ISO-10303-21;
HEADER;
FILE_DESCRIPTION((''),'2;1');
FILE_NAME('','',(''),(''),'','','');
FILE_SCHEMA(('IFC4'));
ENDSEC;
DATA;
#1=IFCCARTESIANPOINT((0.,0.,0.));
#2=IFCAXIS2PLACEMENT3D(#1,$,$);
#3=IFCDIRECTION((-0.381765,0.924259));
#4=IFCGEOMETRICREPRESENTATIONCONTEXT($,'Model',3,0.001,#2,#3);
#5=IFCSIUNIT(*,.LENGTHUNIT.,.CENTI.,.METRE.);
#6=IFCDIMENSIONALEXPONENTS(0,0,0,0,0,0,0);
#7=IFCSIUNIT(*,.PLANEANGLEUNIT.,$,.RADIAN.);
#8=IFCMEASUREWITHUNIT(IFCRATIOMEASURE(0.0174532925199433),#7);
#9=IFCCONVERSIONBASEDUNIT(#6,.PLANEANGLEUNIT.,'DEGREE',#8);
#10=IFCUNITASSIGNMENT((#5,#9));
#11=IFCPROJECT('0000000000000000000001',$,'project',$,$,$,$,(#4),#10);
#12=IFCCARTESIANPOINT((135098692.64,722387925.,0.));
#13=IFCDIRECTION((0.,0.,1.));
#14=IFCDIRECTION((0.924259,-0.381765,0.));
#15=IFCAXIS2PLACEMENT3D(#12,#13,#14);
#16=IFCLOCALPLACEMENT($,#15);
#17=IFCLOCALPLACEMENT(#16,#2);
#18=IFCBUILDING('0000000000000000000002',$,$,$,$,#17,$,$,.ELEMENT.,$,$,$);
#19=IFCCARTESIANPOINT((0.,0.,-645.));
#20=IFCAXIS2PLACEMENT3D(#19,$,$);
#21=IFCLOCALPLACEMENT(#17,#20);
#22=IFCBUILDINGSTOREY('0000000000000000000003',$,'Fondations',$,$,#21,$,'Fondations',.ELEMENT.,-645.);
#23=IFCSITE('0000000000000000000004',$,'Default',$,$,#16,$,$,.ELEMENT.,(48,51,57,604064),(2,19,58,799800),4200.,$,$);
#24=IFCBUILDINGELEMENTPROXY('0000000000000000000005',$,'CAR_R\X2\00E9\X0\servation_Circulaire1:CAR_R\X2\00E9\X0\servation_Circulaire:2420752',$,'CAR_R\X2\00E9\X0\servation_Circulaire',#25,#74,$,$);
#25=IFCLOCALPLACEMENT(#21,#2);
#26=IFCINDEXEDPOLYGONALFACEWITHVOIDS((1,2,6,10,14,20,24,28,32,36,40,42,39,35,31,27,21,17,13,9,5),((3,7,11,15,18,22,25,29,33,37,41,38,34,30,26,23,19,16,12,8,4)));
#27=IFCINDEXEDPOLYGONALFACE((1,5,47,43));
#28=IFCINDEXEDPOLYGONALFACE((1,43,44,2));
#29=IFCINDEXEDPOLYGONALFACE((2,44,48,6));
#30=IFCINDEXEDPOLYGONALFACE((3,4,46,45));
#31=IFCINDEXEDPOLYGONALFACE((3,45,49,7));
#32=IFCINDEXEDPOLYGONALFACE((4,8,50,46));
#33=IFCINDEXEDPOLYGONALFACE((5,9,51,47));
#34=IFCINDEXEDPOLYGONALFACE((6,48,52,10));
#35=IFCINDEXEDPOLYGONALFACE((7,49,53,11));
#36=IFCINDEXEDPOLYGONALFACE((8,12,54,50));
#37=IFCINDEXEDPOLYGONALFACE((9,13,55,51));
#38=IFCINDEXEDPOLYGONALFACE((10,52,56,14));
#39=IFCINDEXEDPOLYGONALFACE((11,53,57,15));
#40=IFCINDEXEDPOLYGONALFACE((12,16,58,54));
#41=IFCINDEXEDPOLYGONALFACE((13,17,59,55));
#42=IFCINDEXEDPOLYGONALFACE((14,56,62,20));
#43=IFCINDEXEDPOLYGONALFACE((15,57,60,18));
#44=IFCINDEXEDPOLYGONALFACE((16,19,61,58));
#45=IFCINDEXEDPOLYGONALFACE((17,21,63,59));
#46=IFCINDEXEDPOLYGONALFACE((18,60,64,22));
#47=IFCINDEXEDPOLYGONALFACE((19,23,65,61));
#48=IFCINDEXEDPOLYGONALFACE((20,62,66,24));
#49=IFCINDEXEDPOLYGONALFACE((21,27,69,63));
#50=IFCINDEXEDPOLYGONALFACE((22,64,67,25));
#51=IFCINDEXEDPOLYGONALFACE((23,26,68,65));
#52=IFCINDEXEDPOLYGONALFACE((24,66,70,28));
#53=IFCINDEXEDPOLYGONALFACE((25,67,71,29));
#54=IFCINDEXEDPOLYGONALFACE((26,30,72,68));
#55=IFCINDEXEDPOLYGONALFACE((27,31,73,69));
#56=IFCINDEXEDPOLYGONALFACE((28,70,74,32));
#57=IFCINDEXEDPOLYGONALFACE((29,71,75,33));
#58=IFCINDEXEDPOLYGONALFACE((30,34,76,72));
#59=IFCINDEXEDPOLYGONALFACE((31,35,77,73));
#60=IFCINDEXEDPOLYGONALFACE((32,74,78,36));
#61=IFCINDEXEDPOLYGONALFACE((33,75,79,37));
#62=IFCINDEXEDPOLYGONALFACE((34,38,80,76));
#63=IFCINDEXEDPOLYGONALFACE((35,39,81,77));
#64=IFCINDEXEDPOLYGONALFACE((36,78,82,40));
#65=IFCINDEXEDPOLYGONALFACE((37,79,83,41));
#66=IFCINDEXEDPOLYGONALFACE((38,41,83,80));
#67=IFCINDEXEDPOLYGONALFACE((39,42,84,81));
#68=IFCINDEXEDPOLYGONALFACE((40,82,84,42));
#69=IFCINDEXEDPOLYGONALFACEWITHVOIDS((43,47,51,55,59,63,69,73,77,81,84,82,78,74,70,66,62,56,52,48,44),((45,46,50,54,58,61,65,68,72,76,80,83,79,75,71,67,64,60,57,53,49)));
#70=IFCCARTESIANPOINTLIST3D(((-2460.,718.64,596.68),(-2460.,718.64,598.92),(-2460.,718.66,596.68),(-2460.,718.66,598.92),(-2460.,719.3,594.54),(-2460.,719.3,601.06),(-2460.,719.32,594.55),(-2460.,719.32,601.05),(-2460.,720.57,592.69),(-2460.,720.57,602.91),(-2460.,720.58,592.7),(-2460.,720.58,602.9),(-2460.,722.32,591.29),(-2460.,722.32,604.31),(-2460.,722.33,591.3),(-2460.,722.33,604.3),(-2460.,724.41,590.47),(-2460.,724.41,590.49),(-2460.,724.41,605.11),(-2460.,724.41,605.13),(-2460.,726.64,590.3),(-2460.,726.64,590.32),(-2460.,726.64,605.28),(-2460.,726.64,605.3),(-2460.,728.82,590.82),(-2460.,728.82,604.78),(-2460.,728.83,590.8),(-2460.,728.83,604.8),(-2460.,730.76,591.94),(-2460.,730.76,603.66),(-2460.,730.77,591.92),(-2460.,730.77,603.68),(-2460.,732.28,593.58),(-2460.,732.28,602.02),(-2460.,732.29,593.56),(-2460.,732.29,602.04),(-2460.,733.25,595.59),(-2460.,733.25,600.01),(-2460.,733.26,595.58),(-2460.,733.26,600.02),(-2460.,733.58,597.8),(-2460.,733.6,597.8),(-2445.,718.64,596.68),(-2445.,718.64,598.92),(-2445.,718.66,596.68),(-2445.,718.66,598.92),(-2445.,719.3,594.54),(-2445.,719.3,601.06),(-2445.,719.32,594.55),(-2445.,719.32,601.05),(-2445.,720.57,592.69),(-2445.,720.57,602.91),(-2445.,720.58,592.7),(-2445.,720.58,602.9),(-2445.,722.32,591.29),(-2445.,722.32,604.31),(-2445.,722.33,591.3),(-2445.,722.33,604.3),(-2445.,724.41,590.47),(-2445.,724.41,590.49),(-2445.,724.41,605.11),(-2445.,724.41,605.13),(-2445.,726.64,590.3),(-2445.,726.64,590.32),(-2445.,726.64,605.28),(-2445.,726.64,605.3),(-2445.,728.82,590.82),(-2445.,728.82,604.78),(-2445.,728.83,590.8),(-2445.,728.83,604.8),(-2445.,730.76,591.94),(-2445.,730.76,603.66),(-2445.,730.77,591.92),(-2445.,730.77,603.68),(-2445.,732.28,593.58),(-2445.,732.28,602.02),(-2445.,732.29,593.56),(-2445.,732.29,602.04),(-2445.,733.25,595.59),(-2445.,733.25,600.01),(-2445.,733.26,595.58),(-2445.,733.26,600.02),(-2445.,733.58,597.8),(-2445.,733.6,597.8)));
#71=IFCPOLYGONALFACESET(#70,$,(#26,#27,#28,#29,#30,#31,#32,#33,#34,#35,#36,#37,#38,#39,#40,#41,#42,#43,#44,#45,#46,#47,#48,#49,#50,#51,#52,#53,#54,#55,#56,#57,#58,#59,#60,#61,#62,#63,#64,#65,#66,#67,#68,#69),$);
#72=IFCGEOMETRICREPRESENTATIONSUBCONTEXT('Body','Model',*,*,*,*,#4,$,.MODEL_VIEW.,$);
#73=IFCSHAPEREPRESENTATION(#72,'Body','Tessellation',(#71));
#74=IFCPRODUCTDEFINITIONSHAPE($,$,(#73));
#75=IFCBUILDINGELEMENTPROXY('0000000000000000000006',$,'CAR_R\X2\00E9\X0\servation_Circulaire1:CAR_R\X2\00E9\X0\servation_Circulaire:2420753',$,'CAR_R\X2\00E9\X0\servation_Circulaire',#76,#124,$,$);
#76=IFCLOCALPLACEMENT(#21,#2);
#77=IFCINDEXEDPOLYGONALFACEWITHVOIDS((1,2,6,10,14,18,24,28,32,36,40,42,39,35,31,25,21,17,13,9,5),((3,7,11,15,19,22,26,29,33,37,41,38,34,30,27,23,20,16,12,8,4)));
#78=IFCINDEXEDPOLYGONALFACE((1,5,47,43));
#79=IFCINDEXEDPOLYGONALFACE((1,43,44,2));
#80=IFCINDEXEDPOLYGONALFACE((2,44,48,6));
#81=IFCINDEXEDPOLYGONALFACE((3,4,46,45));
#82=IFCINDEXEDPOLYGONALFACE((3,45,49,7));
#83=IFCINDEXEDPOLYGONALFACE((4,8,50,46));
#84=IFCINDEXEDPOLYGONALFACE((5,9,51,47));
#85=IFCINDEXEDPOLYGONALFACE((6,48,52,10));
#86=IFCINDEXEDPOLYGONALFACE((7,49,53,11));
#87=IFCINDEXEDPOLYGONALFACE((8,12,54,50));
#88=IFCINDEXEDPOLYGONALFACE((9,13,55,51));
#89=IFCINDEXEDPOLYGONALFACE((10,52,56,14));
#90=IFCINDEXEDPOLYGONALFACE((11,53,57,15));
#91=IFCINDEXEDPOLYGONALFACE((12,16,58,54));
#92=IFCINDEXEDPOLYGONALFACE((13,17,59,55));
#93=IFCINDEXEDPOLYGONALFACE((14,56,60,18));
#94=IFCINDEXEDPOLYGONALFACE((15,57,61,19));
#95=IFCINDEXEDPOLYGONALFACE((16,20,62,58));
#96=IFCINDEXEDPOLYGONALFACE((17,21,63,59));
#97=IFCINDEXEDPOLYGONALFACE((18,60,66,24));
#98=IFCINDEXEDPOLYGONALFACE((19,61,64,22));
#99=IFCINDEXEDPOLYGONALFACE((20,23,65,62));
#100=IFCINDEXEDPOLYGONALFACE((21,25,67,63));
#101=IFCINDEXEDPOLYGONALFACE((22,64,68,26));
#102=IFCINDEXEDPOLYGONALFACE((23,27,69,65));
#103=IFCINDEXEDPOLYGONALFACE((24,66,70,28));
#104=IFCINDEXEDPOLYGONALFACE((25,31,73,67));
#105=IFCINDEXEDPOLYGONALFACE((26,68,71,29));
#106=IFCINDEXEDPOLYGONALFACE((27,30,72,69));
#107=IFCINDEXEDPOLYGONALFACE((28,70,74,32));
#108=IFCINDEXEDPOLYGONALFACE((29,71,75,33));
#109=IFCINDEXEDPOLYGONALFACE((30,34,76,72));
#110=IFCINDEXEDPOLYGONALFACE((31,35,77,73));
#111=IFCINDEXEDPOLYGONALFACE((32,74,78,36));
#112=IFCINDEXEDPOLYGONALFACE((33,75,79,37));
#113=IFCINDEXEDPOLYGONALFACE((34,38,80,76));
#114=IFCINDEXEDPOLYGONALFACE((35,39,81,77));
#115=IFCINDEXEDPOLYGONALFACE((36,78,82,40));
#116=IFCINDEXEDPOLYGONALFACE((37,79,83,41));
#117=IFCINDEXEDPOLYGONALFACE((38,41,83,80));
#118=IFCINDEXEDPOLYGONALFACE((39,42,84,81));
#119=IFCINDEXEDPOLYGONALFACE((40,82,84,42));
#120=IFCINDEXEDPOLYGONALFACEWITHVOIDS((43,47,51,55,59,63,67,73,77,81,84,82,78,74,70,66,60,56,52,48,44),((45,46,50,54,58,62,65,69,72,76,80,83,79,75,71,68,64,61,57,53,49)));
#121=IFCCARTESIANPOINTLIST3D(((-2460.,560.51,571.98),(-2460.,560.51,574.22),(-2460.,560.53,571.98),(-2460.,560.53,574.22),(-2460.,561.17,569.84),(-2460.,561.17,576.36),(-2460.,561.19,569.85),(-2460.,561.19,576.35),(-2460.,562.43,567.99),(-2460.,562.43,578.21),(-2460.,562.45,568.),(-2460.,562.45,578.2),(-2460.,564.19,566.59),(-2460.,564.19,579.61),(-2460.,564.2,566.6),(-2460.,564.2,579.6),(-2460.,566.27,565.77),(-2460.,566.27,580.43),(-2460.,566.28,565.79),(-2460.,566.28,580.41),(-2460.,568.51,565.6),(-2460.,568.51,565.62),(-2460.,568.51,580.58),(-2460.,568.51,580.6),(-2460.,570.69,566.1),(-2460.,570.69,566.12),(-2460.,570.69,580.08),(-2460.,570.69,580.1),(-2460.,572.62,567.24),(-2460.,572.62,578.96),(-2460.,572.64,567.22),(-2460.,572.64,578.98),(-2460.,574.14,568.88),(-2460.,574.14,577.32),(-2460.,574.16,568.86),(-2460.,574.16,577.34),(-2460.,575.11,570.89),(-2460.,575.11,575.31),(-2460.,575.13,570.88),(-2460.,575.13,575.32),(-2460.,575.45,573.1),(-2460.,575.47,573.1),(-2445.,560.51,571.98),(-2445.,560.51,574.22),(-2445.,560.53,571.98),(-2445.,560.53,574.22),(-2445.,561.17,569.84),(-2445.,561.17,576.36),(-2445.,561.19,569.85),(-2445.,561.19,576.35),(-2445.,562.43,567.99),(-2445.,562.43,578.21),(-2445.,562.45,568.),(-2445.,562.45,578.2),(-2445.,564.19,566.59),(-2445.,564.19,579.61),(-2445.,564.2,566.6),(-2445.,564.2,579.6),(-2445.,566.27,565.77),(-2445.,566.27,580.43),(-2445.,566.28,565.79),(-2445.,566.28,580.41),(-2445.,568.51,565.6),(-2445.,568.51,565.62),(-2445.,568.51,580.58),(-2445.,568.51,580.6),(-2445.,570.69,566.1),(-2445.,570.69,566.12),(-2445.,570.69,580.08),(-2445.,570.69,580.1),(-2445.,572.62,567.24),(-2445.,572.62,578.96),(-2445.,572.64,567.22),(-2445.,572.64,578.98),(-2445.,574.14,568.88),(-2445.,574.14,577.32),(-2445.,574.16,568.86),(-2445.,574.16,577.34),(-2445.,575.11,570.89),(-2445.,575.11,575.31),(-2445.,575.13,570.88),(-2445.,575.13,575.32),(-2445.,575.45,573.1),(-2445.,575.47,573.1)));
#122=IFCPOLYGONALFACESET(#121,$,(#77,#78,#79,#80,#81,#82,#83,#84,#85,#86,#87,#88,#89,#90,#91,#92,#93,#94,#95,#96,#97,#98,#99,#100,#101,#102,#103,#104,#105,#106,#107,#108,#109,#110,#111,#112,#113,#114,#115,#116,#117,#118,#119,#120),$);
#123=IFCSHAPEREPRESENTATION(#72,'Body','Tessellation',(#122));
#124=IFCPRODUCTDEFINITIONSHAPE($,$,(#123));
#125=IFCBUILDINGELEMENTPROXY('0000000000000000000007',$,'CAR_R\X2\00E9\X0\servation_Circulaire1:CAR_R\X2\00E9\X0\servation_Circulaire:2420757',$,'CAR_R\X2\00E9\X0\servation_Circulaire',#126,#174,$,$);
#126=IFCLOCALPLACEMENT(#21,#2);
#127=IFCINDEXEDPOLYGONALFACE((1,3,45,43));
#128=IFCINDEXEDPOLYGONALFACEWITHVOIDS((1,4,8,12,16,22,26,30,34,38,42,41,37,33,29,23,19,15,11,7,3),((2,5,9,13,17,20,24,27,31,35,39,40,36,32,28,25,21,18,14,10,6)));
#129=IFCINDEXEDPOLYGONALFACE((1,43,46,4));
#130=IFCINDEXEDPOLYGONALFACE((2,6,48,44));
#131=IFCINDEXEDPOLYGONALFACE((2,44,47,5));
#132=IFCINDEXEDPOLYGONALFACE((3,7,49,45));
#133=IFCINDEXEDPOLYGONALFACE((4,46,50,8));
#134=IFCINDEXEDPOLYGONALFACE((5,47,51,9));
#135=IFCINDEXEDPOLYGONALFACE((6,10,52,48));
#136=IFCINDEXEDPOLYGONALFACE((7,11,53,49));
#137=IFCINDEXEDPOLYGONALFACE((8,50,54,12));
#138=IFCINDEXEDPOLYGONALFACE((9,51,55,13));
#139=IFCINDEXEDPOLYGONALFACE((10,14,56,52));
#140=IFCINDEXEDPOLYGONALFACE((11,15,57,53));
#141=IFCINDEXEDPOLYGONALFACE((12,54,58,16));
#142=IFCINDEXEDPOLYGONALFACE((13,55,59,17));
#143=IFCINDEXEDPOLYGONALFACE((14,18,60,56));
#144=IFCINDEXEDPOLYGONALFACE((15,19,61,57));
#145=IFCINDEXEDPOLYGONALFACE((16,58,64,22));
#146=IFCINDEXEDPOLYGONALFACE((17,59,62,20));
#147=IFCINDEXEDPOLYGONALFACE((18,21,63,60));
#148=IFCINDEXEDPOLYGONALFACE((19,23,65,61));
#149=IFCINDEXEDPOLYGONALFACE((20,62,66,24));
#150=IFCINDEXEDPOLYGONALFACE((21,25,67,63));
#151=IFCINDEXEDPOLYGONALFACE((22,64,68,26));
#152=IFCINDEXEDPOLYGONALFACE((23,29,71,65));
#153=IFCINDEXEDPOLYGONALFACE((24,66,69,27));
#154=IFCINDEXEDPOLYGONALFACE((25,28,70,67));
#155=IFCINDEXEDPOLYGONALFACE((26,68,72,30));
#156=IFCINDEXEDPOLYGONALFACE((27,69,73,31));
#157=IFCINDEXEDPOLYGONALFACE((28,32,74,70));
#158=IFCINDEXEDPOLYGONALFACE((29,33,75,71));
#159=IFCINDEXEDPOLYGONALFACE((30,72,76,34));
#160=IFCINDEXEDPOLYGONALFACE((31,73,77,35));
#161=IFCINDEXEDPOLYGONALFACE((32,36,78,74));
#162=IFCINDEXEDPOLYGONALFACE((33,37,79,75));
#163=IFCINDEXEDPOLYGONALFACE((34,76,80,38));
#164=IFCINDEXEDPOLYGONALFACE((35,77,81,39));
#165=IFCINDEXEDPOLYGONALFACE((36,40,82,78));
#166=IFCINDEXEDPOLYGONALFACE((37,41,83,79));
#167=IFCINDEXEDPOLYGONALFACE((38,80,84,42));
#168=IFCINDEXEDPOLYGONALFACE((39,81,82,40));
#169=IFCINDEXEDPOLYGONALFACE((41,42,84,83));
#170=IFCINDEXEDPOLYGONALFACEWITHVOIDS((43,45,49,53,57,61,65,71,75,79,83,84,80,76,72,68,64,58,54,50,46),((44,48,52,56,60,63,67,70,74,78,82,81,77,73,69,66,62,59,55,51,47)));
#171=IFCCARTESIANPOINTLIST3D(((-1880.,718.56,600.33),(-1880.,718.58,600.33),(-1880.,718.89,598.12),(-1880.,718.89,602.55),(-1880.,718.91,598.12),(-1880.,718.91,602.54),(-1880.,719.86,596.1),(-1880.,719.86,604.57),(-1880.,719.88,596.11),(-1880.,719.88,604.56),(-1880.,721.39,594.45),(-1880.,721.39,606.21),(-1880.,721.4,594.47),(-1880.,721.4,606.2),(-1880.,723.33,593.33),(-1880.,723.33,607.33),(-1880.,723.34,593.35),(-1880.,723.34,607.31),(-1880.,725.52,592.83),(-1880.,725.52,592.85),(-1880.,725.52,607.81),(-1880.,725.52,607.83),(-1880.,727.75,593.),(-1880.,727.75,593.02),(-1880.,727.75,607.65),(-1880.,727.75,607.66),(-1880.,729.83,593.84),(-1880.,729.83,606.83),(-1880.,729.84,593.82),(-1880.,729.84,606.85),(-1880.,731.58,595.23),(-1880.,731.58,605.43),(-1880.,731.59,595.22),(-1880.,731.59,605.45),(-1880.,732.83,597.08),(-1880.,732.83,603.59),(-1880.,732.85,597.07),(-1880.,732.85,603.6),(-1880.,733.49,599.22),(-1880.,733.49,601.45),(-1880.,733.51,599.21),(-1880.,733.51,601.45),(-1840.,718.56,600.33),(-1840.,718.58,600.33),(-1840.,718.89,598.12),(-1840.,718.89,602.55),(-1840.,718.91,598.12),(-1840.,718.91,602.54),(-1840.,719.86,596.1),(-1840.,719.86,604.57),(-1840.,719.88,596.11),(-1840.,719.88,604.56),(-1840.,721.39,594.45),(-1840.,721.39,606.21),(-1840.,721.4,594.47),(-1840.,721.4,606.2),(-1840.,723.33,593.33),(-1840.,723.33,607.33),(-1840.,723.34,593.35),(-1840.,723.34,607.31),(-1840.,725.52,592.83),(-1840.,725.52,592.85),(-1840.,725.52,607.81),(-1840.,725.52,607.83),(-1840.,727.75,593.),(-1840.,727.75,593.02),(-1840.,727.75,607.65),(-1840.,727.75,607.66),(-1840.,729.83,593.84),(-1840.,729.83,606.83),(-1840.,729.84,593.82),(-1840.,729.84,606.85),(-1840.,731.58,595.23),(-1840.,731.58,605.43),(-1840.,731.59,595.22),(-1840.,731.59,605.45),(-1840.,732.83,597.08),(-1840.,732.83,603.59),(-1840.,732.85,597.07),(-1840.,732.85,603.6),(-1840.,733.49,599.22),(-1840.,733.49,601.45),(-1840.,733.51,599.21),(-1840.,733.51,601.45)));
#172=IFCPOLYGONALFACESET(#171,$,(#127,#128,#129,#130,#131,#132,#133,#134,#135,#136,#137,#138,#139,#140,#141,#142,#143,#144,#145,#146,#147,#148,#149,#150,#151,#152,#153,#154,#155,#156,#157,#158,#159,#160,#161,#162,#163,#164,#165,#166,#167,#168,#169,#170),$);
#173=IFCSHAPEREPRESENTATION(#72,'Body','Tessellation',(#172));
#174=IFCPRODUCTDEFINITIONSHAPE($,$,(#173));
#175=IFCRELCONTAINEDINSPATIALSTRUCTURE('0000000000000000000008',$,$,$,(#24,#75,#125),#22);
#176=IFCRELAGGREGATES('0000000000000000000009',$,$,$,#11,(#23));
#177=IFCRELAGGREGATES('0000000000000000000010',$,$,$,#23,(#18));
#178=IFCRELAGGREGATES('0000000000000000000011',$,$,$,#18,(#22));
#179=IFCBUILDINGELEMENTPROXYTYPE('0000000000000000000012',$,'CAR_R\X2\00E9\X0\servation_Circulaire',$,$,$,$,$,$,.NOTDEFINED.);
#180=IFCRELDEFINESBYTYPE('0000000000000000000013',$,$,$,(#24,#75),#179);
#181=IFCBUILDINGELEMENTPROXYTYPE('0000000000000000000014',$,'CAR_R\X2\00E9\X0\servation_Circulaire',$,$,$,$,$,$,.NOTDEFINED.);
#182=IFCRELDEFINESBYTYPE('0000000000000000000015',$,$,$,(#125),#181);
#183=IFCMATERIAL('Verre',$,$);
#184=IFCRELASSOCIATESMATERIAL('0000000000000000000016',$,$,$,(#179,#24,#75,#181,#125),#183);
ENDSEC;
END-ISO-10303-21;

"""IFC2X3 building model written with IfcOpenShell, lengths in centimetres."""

from ifc_helpers import new_model, entity, si_unit, converted_unit, direction, frame, frame_2d, origin, place, context, subcontext, project, spatial, hollow_circle, extrude, source, transform, mapped, material, type_object, type_shapes, element, save


model = new_model("IFC2X3")

# Units and contexts
model_context = context("Model", 3, precision=0.001, world=origin(), true_north=direction((-0.381765, 0.924259)))
body_context = subcontext(model_context, "Body", "Model", "MODEL_VIEW")
ifc_project = project(units=[si_unit("LENGTHUNIT", "METRE", prefix="CENTI"), converted_unit("PLANEANGLEUNIT", "DEGREE", entity("IfcRatioMeasure", 0.0174532925199433), si_unit("PLANEANGLEUNIT", "RADIAN"), dimensions=[0, 0, 0, 0, 0, 0, 0])], contexts=[model_context])

# Site, building, storey
site_placement = place(None, frame((135098692.64, 722387925.0, 0.0), z_axis=(0.0, 0.0, 1.0), x_axis=(0.924259, -0.381765, 0.0)))
site = spatial("IfcSite", under=ifc_project, at=site_placement, Name="Default", CompositionType="ELEMENT", RefLatitude=(48, 51, 57, 604064), RefLongitude=(2, 19, 58, 799800), RefElevation=4200.0)
building_placement = place(site_placement, origin())
building = spatial("IfcBuilding", under=site, at=building_placement, CompositionType="ELEMENT")
storey_placement = place(building_placement, frame((0.0, 0.0, -645.0)))
storey = spatial("IfcBuildingStorey", under=building, at=storey_placement, Name="Fondations", LongName="Fondations", CompositionType="ELEMENT", Elevation=-645.0)

# Building element proxies
ifc_material_1 = material(Name="Verre")
building_element_proxy_type_1 = type_object("IfcBuildingElementProxyType", Name="CAR_Réservation_Circulaire", PredefinedType="NOTDEFINED", material=ifc_material_1)
shared_shape_1 = source(origin(), body_context, "Body", "SweptSolid", [
    extrude(hollow_circle(Radius=7.52, WallThickness=0.02, at=frame_2d((0.0, 0.0), x_axis=(1.0, 0.0))), frame((0.0, 0.0, -15.0)), (0.0, 0.0, 1.0), 15.0),
])
type_shapes(building_element_proxy_type_1, [shared_shape_1])
for number, where, z_axis, x_axis, name in (
    (1, (-2445.0, 726.08, 597.8), (1.0, 0.0, 0.0), (0.0, 1.0, 0.0), "CAR_Réservation_Circulaire1:CAR_Réservation_Circulaire:2420752"),
    (2, (-2445.0, 567.95, 573.1), (1.0, 0.0, 0.0), (0.0, 1.0, 0.0), "CAR_Réservation_Circulaire1:CAR_Réservation_Circulaire:2420753"),
):
    element("IfcBuildingElementProxy", number, at=place(storey_placement, frame(where, z_axis=z_axis, x_axis=x_axis)), inside=storey, type_object=building_element_proxy_type_1, material=ifc_material_1, Name=name, ObjectType="CAR_Réservation_Circulaire", context=body_context, shape_type="MappedRepresentation", body=[
        mapped(shared_shape_1, transform((0.0, 0.0, 0.0), scale=1.0)),
    ])
building_element_proxy_type_2 = type_object("IfcBuildingElementProxyType", Name="CAR_Réservation_Circulaire", PredefinedType="NOTDEFINED", material=ifc_material_1)
shared_shape_2 = source(origin(), body_context, "Body", "SweptSolid", [
    extrude(hollow_circle(Radius=7.52, WallThickness=0.02, at=frame_2d((0.0, 0.0), x_axis=(1.0, 0.0))), frame((0.0, 0.0, -40.0)), (0.0, 0.0, 1.0), 40.0),
])
type_shapes(building_element_proxy_type_2, [shared_shape_2])
for number, where, z_axis, x_axis, name in (
    (3, (-1880.0, 726.08, 600.33), (-1.0, 0.0, 0.0), (0.0, -1.0, 0.0), "CAR_Réservation_Circulaire1:CAR_Réservation_Circulaire:2420757"),
):
    element("IfcBuildingElementProxy", number, at=place(storey_placement, frame(where, z_axis=z_axis, x_axis=x_axis)), inside=storey, type_object=building_element_proxy_type_2, material=ifc_material_1, Name=name, ObjectType="CAR_Réservation_Circulaire", context=body_context, shape_type="MappedRepresentation", body=[
        mapped(shared_shape_2, transform((0.0, 0.0, 0.0), scale=1.0)),
    ])

save(model, "model.ifc")
